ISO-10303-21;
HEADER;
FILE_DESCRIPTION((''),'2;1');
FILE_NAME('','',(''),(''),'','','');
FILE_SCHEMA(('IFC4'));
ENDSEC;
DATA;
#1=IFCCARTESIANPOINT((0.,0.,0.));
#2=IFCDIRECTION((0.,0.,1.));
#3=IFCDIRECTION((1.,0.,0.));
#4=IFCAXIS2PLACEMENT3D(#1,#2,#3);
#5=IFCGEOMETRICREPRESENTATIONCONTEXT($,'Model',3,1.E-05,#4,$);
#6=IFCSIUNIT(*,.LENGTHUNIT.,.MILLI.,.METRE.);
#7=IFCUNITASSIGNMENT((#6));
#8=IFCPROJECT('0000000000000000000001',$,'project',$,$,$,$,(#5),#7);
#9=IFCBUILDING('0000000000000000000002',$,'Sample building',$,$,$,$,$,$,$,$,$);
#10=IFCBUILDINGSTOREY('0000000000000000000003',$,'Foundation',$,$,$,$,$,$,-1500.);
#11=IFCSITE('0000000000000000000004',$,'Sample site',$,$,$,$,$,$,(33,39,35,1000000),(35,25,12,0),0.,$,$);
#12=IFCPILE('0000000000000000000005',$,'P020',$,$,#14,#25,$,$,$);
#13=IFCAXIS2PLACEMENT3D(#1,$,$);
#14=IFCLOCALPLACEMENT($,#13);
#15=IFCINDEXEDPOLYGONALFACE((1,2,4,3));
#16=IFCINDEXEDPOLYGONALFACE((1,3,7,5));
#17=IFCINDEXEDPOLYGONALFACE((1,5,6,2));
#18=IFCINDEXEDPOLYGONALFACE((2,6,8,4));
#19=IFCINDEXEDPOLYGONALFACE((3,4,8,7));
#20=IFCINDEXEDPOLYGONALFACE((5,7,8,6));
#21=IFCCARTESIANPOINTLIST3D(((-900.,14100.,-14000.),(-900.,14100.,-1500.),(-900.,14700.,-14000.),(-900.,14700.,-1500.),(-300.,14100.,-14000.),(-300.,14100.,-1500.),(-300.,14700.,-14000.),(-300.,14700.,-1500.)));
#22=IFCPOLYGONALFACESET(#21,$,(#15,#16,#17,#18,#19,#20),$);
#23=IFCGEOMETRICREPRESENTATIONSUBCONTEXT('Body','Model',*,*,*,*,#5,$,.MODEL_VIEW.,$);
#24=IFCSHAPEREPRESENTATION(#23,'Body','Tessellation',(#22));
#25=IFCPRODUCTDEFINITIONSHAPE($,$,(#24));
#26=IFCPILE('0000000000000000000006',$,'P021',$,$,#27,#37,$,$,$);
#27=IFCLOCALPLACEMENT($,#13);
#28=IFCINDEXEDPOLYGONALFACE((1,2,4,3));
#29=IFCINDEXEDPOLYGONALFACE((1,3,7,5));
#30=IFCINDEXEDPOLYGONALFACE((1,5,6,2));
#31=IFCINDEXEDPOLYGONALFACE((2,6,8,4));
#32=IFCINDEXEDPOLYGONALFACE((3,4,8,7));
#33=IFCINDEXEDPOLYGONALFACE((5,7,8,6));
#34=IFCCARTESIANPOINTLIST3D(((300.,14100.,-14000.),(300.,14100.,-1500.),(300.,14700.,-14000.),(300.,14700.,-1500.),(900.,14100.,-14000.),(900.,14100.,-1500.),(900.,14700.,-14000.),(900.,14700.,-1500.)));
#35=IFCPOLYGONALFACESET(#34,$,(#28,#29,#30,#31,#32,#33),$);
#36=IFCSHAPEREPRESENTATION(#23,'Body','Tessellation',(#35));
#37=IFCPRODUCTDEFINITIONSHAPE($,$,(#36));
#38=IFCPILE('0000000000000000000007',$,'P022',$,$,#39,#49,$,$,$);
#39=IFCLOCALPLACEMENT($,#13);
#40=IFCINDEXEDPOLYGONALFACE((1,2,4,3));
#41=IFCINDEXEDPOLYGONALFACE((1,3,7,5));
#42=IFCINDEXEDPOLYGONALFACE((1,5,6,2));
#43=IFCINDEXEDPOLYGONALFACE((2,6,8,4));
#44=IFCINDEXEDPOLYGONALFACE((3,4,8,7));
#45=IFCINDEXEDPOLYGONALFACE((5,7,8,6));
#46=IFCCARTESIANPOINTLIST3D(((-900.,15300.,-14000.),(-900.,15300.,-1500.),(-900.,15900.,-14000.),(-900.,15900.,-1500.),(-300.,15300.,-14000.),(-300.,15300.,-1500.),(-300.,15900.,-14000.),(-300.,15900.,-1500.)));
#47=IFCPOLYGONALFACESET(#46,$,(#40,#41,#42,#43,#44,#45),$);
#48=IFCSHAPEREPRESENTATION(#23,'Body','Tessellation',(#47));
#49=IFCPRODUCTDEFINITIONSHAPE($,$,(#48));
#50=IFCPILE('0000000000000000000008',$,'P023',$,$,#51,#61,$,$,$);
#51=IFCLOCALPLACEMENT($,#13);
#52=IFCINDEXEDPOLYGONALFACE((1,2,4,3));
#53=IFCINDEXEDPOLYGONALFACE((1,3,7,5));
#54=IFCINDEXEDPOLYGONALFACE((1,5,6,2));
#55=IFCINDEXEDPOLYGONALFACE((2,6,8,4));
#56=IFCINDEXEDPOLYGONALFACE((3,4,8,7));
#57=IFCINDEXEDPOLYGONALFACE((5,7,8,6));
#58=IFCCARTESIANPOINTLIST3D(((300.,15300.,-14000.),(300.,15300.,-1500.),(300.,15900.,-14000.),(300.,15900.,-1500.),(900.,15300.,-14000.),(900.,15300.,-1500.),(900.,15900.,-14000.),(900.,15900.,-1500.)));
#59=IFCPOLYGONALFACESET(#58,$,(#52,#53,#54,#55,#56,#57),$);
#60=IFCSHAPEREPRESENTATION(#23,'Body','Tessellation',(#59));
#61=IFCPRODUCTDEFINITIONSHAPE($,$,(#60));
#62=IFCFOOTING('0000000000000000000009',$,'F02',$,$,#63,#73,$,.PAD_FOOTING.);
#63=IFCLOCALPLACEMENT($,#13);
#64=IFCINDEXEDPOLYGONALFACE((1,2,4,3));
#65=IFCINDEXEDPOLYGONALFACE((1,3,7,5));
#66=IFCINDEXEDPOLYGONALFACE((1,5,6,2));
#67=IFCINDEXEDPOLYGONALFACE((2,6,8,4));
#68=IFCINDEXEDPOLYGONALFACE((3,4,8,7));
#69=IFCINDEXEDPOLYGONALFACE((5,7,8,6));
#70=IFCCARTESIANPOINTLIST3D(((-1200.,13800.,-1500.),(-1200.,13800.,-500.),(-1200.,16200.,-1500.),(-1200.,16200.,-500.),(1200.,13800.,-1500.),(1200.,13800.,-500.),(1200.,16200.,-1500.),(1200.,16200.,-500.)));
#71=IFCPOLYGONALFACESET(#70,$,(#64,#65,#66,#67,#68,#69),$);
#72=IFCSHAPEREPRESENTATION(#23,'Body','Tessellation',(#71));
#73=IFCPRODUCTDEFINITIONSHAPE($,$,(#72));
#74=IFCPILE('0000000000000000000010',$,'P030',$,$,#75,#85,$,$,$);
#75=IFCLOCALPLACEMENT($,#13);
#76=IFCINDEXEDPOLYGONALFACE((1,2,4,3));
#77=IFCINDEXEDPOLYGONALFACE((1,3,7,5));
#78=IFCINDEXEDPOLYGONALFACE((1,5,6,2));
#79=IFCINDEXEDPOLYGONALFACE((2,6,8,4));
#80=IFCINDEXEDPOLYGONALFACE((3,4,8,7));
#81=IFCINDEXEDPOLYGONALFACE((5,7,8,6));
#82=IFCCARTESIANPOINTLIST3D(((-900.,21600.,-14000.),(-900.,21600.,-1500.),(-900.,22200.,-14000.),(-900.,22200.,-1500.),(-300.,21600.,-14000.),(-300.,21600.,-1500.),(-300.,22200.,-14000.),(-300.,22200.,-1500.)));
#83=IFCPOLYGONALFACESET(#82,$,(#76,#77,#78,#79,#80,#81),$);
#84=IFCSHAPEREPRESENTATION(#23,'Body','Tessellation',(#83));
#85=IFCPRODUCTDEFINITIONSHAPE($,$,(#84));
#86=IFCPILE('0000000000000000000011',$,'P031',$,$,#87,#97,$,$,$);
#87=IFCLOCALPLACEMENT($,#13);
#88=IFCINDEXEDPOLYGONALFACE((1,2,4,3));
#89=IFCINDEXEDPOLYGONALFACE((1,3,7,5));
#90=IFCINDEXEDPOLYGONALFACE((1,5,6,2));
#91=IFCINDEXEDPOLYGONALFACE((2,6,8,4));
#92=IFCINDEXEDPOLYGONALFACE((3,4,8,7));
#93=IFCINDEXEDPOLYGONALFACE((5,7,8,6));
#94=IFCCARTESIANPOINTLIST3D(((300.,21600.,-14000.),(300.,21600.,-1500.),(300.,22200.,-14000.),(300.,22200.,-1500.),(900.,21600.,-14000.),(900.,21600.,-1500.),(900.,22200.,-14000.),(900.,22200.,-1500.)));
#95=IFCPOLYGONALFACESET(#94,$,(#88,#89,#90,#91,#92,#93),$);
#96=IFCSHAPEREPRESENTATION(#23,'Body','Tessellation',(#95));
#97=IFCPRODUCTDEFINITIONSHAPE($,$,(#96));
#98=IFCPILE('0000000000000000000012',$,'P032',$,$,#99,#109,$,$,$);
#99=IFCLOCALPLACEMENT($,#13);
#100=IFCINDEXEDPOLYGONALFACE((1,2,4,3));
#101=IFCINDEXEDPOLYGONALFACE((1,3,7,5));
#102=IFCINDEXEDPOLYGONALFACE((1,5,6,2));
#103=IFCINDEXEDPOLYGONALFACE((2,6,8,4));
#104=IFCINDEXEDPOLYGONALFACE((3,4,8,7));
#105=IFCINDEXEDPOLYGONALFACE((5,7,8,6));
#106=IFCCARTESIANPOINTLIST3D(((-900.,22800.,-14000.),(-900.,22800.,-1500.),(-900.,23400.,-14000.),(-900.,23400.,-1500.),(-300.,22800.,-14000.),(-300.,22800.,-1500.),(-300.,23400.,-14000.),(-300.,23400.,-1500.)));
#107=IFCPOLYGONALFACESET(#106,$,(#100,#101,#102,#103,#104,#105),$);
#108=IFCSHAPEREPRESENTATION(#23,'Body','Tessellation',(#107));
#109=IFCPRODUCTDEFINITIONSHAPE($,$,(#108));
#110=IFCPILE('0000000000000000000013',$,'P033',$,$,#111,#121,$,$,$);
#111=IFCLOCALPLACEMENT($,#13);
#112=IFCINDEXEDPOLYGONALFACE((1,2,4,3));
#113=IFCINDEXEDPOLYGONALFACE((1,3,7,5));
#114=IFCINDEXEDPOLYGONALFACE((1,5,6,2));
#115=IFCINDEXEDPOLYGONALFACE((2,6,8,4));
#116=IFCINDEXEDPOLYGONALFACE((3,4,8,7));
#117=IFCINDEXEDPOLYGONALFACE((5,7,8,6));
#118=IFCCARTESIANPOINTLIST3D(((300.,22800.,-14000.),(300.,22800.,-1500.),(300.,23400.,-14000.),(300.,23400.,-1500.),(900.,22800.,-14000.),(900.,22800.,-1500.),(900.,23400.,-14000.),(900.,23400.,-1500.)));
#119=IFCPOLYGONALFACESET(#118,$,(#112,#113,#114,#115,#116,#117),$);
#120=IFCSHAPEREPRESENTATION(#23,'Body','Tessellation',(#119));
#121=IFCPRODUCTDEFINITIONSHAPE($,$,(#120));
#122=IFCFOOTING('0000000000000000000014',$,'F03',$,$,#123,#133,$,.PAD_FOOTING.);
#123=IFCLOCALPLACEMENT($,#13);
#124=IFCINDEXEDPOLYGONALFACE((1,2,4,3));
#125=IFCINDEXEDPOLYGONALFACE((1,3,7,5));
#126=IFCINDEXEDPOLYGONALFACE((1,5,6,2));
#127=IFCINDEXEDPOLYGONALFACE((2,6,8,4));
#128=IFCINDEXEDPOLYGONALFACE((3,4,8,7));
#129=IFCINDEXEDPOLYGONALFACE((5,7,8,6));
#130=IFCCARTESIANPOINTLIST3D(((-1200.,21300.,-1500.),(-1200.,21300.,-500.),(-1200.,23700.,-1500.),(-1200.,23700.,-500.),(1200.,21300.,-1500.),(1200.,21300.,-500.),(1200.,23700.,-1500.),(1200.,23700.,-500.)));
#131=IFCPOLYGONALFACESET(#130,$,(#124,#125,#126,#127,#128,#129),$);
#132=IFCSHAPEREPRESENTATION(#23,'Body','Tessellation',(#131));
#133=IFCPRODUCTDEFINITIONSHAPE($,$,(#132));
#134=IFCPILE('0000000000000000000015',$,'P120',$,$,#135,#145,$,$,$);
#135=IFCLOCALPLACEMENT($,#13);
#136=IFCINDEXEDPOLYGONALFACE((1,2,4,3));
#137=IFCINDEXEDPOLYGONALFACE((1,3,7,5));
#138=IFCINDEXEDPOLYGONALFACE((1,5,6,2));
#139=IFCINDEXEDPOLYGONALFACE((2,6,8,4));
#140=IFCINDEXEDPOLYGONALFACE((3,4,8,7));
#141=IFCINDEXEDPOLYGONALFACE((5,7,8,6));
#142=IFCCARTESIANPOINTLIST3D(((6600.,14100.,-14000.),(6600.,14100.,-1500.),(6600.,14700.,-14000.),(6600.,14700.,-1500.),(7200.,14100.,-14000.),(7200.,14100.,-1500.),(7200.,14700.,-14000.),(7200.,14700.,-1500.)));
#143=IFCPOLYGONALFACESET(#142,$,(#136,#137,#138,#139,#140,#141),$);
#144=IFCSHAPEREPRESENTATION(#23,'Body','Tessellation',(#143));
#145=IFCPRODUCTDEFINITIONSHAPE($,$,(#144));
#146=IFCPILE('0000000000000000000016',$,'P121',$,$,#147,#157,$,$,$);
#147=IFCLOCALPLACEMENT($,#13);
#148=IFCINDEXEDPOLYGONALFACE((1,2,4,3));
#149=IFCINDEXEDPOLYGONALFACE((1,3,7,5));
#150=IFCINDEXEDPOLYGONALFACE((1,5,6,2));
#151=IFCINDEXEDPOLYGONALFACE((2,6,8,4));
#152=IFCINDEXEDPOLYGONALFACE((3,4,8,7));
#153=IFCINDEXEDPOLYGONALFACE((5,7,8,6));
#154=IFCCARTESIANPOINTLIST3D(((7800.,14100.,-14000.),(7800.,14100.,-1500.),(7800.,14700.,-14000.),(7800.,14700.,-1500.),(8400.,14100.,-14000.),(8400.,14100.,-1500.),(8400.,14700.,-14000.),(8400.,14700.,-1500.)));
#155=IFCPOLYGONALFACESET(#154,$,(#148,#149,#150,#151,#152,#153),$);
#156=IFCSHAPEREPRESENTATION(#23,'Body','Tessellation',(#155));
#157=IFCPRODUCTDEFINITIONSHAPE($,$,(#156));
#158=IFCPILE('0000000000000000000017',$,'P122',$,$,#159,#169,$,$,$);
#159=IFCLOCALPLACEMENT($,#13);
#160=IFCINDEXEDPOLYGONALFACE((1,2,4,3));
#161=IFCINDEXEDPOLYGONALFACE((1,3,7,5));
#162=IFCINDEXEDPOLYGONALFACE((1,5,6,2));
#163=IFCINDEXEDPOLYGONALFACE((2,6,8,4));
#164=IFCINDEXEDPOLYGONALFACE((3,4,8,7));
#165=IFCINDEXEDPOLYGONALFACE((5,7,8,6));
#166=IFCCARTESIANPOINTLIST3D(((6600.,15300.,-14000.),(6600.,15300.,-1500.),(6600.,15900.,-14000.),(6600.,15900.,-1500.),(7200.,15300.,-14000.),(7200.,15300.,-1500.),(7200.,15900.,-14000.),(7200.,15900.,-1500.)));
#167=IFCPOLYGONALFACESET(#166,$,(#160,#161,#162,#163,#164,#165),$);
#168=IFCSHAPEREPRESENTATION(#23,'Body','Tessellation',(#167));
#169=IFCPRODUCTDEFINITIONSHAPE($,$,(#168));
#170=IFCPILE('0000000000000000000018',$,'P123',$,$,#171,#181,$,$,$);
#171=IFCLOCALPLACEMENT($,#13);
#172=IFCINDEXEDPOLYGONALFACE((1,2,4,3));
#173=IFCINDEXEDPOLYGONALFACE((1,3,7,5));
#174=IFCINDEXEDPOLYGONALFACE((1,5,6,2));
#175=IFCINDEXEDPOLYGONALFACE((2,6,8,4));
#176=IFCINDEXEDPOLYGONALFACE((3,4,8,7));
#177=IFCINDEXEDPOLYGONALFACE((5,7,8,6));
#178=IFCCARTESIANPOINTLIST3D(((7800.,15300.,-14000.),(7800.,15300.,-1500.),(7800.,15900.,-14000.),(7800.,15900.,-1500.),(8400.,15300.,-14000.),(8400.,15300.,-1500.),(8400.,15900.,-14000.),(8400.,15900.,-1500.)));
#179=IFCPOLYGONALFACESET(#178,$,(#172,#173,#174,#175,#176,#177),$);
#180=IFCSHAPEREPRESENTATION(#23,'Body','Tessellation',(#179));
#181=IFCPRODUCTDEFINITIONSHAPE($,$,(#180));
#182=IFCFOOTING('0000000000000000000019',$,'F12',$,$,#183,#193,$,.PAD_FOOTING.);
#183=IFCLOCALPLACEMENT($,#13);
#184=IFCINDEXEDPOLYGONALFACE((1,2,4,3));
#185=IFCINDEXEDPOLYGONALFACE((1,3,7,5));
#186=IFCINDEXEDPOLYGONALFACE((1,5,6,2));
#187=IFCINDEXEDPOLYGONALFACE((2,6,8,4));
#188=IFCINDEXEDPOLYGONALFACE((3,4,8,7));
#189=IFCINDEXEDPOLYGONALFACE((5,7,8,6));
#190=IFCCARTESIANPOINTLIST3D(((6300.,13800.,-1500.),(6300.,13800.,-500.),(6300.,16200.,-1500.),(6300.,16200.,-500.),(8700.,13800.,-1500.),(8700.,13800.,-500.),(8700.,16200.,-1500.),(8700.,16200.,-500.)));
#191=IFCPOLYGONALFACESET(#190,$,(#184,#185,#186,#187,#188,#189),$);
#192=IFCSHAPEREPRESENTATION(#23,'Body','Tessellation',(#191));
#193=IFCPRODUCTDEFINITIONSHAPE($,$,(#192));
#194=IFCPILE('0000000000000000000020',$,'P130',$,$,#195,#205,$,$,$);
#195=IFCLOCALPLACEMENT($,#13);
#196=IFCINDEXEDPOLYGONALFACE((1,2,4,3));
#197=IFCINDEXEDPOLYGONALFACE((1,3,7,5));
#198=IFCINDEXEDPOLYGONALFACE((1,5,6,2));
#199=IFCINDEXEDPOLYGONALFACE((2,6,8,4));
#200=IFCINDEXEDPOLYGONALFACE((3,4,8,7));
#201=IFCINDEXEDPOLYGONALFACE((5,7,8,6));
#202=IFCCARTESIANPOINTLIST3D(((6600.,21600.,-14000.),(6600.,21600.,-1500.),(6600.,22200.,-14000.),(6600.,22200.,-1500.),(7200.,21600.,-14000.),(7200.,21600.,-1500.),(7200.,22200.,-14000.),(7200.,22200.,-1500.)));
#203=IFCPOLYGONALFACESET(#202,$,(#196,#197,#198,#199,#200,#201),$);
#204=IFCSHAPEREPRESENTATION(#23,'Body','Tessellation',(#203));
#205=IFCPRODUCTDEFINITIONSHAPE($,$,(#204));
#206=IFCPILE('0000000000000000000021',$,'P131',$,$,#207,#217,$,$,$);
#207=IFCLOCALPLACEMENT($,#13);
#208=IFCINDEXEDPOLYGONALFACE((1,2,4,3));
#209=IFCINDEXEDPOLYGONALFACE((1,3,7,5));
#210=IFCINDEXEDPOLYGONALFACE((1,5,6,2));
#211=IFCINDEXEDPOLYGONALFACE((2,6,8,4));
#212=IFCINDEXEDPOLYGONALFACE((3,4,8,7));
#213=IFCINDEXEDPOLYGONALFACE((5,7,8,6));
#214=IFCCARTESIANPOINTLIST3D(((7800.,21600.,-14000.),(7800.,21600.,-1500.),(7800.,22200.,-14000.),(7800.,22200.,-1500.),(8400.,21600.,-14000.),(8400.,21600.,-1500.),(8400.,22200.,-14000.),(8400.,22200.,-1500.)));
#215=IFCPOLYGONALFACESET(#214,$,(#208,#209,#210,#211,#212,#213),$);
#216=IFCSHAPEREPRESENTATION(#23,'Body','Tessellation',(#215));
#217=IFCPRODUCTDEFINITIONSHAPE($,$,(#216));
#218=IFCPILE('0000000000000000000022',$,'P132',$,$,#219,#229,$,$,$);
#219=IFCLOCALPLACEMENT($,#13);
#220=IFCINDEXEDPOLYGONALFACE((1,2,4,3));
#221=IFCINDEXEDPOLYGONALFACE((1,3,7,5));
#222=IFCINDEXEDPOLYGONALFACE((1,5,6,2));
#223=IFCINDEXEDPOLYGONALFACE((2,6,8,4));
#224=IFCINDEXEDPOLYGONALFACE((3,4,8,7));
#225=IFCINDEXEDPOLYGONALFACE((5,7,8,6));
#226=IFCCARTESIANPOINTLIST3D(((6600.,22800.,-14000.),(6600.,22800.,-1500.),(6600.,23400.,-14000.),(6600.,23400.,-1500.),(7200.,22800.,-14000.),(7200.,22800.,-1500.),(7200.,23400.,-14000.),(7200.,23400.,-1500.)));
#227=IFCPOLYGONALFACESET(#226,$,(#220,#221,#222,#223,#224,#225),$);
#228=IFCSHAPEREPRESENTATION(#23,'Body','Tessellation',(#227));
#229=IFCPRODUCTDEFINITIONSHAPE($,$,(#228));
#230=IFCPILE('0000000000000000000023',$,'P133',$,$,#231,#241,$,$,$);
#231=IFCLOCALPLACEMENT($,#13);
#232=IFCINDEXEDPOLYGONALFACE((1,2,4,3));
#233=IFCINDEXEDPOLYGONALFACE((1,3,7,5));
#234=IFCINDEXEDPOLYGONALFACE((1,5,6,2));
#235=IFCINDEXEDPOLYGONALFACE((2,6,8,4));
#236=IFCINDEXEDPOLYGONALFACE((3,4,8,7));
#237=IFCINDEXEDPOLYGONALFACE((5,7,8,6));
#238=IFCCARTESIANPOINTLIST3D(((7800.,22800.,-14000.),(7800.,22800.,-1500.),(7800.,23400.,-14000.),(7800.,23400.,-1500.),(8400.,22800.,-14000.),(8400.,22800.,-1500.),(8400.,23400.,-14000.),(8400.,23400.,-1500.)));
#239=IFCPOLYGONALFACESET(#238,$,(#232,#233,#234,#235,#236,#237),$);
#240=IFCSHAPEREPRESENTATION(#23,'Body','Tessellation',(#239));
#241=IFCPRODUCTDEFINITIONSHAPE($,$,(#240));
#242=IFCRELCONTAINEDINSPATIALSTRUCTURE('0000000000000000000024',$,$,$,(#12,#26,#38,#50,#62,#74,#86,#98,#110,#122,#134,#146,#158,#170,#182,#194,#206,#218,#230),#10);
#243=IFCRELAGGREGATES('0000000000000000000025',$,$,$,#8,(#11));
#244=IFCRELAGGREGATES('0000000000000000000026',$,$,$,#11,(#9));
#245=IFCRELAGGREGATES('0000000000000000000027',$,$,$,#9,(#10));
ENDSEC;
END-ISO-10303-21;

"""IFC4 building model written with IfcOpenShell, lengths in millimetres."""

from ifc_helpers import new_model, si_unit, frame, origin_with_axes, place, context, subcontext, project, spatial, indexed_curve, outline, extrude, element, save


model = new_model("IFC4")

# Units and contexts
model_context = context("Model", 3, precision=1e-05, world=origin_with_axes())
body_context = subcontext(model_context, "Body", "Model", "MODEL_VIEW")
ifc_project = project(units=[si_unit("LENGTHUNIT", "METRE", prefix="MILLI")], contexts=[model_context])

# Site, building, storey
site = spatial("IfcSite", under=ifc_project, Name="Sample site", RefLatitude=(33, 39, 35, 1000000), RefLongitude=(35, 25, 12, 0), RefElevation=0.0)
building = spatial("IfcBuilding", under=site, Name="Sample building")
storey = spatial("IfcBuildingStorey", under=building, Name="Foundation", Elevation=-1500.0)

# Piles
for number, where, z_axis, x_axis, name in (
    (1, (-900.0, 14100.0, -14000.0), (0.0, 0.0, 1.0), (1.0, 0.0, 0.0), "P020"),
    (2, (300.0, 14100.0, -14000.0), (0.0, 0.0, 1.0), (1.0, 0.0, 0.0), "P021"),
    (3, (-900.0, 15300.0, -14000.0), (0.0, 0.0, 1.0), (1.0, 0.0, 0.0), "P022"),
    (4, (300.0, 15300.0, -14000.0), (0.0, 0.0, 1.0), (1.0, 0.0, 0.0), "P023"),
):
    element("IfcPile", number, at=place(None, frame(where, z_axis=z_axis, x_axis=x_axis)), inside=storey, Name=name, context=body_context, shape_type="SweptSolid", body=[
        extrude(outline(indexed_curve([(0.0, 0.0), (0.0, 600.0), (600.0, 600.0), (600.0, 0.0), (0.0, 0.0)], self_intersect=False)), origin_with_axes(), (0.0, 0.0, 1.0), 12500.0),
    ])

# Footing
footing_1_placement = place(None, frame((-1200.0, 13800.0, -1500.0), z_axis=(0.0, 0.0, 1.0), x_axis=(1.0, 0.0, 0.0)))
element("IfcFooting", 5, at=footing_1_placement, inside=storey, Name="F02", PredefinedType="PAD_FOOTING", context=body_context, shape_type="SweptSolid", body=[
    extrude(outline(indexed_curve([(0.0, 0.0), (0.0, 2400.0), (2400.0, 2400.0), (2400.0, 0.0), (0.0, 0.0)], self_intersect=False)), origin_with_axes(), (0.0, 0.0, 1.0), 1000.0),
])

# Piles
for number, where, z_axis, x_axis, name in (
    (6, (-900.0, 21600.0, -14000.0), (0.0, 0.0, 1.0), (1.0, 0.0, 0.0), "P030"),
    (7, (300.0, 21600.0, -14000.0), (0.0, 0.0, 1.0), (1.0, 0.0, 0.0), "P031"),
    (8, (-900.0, 22800.0, -14000.0), (0.0, 0.0, 1.0), (1.0, 0.0, 0.0), "P032"),
    (9, (300.0, 22800.0, -14000.0), (0.0, 0.0, 1.0), (1.0, 0.0, 0.0), "P033"),
):
    element("IfcPile", number, at=place(None, frame(where, z_axis=z_axis, x_axis=x_axis)), inside=storey, Name=name, context=body_context, shape_type="SweptSolid", body=[
        extrude(outline(indexed_curve([(0.0, 0.0), (0.0, 600.0), (600.0, 600.0), (600.0, 0.0), (0.0, 0.0)], self_intersect=False)), origin_with_axes(), (0.0, 0.0, 1.0), 12500.0),
    ])

# Footing
footing_2_placement = place(None, frame((-1200.0, 21300.0, -1500.0), z_axis=(0.0, 0.0, 1.0), x_axis=(1.0, 0.0, 0.0)))
element("IfcFooting", 10, at=footing_2_placement, inside=storey, Name="F03", PredefinedType="PAD_FOOTING", context=body_context, shape_type="SweptSolid", body=[
    extrude(outline(indexed_curve([(0.0, 0.0), (0.0, 2400.0), (2400.0, 2400.0), (2400.0, 0.0), (0.0, 0.0)], self_intersect=False)), origin_with_axes(), (0.0, 0.0, 1.0), 1000.0),
])

# Piles
for number, where, z_axis, x_axis, name in (
    (11, (6600.0, 14100.0, -14000.0), (0.0, 0.0, 1.0), (1.0, 0.0, 0.0), "P120"),
    (12, (7800.0, 14100.0, -14000.0), (0.0, 0.0, 1.0), (1.0, 0.0, 0.0), "P121"),
    (13, (6600.0, 15300.0, -14000.0), (0.0, 0.0, 1.0), (1.0, 0.0, 0.0), "P122"),
    (14, (7800.0, 15300.0, -14000.0), (0.0, 0.0, 1.0), (1.0, 0.0, 0.0), "P123"),
):
    element("IfcPile", number, at=place(None, frame(where, z_axis=z_axis, x_axis=x_axis)), inside=storey, Name=name, context=body_context, shape_type="SweptSolid", body=[
        extrude(outline(indexed_curve([(0.0, 0.0), (0.0, 600.0), (600.0, 600.0), (600.0, 0.0), (0.0, 0.0)], self_intersect=False)), origin_with_axes(), (0.0, 0.0, 1.0), 12500.0),
    ])

# Footing
footing_3_placement = place(None, frame((6300.0, 13800.0, -1500.0), z_axis=(0.0, 0.0, 1.0), x_axis=(1.0, 0.0, 0.0)))
element("IfcFooting", 15, at=footing_3_placement, inside=storey, Name="F12", PredefinedType="PAD_FOOTING", context=body_context, shape_type="SweptSolid", body=[
    extrude(outline(indexed_curve([(0.0, 0.0), (0.0, 2400.0), (2400.0, 2400.0), (2400.0, 0.0), (0.0, 0.0)], self_intersect=False)), origin_with_axes(), (0.0, 0.0, 1.0), 1000.0),
])

# Piles
for number, where, z_axis, x_axis, name in (
    (16, (6600.0, 21600.0, -14000.0), (0.0, 0.0, 1.0), (1.0, 0.0, 0.0), "P130"),
    (17, (7800.0, 21600.0, -14000.0), (0.0, 0.0, 1.0), (1.0, 0.0, 0.0), "P131"),
    (18, (6600.0, 22800.0, -14000.0), (0.0, 0.0, 1.0), (1.0, 0.0, 0.0), "P132"),
    (19, (7800.0, 22800.0, -14000.0), (0.0, 0.0, 1.0), (1.0, 0.0, 0.0), "P133"),
):
    element("IfcPile", number, at=place(None, frame(where, z_axis=z_axis, x_axis=x_axis)), inside=storey, Name=name, context=body_context, shape_type="SweptSolid", body=[
        extrude(outline(indexed_curve([(0.0, 0.0), (0.0, 600.0), (600.0, 600.0), (600.0, 0.0), (0.0, 0.0)], self_intersect=False)), origin_with_axes(), (0.0, 0.0, 1.0), 12500.0),
    ])

save(model, "model.ifc")
